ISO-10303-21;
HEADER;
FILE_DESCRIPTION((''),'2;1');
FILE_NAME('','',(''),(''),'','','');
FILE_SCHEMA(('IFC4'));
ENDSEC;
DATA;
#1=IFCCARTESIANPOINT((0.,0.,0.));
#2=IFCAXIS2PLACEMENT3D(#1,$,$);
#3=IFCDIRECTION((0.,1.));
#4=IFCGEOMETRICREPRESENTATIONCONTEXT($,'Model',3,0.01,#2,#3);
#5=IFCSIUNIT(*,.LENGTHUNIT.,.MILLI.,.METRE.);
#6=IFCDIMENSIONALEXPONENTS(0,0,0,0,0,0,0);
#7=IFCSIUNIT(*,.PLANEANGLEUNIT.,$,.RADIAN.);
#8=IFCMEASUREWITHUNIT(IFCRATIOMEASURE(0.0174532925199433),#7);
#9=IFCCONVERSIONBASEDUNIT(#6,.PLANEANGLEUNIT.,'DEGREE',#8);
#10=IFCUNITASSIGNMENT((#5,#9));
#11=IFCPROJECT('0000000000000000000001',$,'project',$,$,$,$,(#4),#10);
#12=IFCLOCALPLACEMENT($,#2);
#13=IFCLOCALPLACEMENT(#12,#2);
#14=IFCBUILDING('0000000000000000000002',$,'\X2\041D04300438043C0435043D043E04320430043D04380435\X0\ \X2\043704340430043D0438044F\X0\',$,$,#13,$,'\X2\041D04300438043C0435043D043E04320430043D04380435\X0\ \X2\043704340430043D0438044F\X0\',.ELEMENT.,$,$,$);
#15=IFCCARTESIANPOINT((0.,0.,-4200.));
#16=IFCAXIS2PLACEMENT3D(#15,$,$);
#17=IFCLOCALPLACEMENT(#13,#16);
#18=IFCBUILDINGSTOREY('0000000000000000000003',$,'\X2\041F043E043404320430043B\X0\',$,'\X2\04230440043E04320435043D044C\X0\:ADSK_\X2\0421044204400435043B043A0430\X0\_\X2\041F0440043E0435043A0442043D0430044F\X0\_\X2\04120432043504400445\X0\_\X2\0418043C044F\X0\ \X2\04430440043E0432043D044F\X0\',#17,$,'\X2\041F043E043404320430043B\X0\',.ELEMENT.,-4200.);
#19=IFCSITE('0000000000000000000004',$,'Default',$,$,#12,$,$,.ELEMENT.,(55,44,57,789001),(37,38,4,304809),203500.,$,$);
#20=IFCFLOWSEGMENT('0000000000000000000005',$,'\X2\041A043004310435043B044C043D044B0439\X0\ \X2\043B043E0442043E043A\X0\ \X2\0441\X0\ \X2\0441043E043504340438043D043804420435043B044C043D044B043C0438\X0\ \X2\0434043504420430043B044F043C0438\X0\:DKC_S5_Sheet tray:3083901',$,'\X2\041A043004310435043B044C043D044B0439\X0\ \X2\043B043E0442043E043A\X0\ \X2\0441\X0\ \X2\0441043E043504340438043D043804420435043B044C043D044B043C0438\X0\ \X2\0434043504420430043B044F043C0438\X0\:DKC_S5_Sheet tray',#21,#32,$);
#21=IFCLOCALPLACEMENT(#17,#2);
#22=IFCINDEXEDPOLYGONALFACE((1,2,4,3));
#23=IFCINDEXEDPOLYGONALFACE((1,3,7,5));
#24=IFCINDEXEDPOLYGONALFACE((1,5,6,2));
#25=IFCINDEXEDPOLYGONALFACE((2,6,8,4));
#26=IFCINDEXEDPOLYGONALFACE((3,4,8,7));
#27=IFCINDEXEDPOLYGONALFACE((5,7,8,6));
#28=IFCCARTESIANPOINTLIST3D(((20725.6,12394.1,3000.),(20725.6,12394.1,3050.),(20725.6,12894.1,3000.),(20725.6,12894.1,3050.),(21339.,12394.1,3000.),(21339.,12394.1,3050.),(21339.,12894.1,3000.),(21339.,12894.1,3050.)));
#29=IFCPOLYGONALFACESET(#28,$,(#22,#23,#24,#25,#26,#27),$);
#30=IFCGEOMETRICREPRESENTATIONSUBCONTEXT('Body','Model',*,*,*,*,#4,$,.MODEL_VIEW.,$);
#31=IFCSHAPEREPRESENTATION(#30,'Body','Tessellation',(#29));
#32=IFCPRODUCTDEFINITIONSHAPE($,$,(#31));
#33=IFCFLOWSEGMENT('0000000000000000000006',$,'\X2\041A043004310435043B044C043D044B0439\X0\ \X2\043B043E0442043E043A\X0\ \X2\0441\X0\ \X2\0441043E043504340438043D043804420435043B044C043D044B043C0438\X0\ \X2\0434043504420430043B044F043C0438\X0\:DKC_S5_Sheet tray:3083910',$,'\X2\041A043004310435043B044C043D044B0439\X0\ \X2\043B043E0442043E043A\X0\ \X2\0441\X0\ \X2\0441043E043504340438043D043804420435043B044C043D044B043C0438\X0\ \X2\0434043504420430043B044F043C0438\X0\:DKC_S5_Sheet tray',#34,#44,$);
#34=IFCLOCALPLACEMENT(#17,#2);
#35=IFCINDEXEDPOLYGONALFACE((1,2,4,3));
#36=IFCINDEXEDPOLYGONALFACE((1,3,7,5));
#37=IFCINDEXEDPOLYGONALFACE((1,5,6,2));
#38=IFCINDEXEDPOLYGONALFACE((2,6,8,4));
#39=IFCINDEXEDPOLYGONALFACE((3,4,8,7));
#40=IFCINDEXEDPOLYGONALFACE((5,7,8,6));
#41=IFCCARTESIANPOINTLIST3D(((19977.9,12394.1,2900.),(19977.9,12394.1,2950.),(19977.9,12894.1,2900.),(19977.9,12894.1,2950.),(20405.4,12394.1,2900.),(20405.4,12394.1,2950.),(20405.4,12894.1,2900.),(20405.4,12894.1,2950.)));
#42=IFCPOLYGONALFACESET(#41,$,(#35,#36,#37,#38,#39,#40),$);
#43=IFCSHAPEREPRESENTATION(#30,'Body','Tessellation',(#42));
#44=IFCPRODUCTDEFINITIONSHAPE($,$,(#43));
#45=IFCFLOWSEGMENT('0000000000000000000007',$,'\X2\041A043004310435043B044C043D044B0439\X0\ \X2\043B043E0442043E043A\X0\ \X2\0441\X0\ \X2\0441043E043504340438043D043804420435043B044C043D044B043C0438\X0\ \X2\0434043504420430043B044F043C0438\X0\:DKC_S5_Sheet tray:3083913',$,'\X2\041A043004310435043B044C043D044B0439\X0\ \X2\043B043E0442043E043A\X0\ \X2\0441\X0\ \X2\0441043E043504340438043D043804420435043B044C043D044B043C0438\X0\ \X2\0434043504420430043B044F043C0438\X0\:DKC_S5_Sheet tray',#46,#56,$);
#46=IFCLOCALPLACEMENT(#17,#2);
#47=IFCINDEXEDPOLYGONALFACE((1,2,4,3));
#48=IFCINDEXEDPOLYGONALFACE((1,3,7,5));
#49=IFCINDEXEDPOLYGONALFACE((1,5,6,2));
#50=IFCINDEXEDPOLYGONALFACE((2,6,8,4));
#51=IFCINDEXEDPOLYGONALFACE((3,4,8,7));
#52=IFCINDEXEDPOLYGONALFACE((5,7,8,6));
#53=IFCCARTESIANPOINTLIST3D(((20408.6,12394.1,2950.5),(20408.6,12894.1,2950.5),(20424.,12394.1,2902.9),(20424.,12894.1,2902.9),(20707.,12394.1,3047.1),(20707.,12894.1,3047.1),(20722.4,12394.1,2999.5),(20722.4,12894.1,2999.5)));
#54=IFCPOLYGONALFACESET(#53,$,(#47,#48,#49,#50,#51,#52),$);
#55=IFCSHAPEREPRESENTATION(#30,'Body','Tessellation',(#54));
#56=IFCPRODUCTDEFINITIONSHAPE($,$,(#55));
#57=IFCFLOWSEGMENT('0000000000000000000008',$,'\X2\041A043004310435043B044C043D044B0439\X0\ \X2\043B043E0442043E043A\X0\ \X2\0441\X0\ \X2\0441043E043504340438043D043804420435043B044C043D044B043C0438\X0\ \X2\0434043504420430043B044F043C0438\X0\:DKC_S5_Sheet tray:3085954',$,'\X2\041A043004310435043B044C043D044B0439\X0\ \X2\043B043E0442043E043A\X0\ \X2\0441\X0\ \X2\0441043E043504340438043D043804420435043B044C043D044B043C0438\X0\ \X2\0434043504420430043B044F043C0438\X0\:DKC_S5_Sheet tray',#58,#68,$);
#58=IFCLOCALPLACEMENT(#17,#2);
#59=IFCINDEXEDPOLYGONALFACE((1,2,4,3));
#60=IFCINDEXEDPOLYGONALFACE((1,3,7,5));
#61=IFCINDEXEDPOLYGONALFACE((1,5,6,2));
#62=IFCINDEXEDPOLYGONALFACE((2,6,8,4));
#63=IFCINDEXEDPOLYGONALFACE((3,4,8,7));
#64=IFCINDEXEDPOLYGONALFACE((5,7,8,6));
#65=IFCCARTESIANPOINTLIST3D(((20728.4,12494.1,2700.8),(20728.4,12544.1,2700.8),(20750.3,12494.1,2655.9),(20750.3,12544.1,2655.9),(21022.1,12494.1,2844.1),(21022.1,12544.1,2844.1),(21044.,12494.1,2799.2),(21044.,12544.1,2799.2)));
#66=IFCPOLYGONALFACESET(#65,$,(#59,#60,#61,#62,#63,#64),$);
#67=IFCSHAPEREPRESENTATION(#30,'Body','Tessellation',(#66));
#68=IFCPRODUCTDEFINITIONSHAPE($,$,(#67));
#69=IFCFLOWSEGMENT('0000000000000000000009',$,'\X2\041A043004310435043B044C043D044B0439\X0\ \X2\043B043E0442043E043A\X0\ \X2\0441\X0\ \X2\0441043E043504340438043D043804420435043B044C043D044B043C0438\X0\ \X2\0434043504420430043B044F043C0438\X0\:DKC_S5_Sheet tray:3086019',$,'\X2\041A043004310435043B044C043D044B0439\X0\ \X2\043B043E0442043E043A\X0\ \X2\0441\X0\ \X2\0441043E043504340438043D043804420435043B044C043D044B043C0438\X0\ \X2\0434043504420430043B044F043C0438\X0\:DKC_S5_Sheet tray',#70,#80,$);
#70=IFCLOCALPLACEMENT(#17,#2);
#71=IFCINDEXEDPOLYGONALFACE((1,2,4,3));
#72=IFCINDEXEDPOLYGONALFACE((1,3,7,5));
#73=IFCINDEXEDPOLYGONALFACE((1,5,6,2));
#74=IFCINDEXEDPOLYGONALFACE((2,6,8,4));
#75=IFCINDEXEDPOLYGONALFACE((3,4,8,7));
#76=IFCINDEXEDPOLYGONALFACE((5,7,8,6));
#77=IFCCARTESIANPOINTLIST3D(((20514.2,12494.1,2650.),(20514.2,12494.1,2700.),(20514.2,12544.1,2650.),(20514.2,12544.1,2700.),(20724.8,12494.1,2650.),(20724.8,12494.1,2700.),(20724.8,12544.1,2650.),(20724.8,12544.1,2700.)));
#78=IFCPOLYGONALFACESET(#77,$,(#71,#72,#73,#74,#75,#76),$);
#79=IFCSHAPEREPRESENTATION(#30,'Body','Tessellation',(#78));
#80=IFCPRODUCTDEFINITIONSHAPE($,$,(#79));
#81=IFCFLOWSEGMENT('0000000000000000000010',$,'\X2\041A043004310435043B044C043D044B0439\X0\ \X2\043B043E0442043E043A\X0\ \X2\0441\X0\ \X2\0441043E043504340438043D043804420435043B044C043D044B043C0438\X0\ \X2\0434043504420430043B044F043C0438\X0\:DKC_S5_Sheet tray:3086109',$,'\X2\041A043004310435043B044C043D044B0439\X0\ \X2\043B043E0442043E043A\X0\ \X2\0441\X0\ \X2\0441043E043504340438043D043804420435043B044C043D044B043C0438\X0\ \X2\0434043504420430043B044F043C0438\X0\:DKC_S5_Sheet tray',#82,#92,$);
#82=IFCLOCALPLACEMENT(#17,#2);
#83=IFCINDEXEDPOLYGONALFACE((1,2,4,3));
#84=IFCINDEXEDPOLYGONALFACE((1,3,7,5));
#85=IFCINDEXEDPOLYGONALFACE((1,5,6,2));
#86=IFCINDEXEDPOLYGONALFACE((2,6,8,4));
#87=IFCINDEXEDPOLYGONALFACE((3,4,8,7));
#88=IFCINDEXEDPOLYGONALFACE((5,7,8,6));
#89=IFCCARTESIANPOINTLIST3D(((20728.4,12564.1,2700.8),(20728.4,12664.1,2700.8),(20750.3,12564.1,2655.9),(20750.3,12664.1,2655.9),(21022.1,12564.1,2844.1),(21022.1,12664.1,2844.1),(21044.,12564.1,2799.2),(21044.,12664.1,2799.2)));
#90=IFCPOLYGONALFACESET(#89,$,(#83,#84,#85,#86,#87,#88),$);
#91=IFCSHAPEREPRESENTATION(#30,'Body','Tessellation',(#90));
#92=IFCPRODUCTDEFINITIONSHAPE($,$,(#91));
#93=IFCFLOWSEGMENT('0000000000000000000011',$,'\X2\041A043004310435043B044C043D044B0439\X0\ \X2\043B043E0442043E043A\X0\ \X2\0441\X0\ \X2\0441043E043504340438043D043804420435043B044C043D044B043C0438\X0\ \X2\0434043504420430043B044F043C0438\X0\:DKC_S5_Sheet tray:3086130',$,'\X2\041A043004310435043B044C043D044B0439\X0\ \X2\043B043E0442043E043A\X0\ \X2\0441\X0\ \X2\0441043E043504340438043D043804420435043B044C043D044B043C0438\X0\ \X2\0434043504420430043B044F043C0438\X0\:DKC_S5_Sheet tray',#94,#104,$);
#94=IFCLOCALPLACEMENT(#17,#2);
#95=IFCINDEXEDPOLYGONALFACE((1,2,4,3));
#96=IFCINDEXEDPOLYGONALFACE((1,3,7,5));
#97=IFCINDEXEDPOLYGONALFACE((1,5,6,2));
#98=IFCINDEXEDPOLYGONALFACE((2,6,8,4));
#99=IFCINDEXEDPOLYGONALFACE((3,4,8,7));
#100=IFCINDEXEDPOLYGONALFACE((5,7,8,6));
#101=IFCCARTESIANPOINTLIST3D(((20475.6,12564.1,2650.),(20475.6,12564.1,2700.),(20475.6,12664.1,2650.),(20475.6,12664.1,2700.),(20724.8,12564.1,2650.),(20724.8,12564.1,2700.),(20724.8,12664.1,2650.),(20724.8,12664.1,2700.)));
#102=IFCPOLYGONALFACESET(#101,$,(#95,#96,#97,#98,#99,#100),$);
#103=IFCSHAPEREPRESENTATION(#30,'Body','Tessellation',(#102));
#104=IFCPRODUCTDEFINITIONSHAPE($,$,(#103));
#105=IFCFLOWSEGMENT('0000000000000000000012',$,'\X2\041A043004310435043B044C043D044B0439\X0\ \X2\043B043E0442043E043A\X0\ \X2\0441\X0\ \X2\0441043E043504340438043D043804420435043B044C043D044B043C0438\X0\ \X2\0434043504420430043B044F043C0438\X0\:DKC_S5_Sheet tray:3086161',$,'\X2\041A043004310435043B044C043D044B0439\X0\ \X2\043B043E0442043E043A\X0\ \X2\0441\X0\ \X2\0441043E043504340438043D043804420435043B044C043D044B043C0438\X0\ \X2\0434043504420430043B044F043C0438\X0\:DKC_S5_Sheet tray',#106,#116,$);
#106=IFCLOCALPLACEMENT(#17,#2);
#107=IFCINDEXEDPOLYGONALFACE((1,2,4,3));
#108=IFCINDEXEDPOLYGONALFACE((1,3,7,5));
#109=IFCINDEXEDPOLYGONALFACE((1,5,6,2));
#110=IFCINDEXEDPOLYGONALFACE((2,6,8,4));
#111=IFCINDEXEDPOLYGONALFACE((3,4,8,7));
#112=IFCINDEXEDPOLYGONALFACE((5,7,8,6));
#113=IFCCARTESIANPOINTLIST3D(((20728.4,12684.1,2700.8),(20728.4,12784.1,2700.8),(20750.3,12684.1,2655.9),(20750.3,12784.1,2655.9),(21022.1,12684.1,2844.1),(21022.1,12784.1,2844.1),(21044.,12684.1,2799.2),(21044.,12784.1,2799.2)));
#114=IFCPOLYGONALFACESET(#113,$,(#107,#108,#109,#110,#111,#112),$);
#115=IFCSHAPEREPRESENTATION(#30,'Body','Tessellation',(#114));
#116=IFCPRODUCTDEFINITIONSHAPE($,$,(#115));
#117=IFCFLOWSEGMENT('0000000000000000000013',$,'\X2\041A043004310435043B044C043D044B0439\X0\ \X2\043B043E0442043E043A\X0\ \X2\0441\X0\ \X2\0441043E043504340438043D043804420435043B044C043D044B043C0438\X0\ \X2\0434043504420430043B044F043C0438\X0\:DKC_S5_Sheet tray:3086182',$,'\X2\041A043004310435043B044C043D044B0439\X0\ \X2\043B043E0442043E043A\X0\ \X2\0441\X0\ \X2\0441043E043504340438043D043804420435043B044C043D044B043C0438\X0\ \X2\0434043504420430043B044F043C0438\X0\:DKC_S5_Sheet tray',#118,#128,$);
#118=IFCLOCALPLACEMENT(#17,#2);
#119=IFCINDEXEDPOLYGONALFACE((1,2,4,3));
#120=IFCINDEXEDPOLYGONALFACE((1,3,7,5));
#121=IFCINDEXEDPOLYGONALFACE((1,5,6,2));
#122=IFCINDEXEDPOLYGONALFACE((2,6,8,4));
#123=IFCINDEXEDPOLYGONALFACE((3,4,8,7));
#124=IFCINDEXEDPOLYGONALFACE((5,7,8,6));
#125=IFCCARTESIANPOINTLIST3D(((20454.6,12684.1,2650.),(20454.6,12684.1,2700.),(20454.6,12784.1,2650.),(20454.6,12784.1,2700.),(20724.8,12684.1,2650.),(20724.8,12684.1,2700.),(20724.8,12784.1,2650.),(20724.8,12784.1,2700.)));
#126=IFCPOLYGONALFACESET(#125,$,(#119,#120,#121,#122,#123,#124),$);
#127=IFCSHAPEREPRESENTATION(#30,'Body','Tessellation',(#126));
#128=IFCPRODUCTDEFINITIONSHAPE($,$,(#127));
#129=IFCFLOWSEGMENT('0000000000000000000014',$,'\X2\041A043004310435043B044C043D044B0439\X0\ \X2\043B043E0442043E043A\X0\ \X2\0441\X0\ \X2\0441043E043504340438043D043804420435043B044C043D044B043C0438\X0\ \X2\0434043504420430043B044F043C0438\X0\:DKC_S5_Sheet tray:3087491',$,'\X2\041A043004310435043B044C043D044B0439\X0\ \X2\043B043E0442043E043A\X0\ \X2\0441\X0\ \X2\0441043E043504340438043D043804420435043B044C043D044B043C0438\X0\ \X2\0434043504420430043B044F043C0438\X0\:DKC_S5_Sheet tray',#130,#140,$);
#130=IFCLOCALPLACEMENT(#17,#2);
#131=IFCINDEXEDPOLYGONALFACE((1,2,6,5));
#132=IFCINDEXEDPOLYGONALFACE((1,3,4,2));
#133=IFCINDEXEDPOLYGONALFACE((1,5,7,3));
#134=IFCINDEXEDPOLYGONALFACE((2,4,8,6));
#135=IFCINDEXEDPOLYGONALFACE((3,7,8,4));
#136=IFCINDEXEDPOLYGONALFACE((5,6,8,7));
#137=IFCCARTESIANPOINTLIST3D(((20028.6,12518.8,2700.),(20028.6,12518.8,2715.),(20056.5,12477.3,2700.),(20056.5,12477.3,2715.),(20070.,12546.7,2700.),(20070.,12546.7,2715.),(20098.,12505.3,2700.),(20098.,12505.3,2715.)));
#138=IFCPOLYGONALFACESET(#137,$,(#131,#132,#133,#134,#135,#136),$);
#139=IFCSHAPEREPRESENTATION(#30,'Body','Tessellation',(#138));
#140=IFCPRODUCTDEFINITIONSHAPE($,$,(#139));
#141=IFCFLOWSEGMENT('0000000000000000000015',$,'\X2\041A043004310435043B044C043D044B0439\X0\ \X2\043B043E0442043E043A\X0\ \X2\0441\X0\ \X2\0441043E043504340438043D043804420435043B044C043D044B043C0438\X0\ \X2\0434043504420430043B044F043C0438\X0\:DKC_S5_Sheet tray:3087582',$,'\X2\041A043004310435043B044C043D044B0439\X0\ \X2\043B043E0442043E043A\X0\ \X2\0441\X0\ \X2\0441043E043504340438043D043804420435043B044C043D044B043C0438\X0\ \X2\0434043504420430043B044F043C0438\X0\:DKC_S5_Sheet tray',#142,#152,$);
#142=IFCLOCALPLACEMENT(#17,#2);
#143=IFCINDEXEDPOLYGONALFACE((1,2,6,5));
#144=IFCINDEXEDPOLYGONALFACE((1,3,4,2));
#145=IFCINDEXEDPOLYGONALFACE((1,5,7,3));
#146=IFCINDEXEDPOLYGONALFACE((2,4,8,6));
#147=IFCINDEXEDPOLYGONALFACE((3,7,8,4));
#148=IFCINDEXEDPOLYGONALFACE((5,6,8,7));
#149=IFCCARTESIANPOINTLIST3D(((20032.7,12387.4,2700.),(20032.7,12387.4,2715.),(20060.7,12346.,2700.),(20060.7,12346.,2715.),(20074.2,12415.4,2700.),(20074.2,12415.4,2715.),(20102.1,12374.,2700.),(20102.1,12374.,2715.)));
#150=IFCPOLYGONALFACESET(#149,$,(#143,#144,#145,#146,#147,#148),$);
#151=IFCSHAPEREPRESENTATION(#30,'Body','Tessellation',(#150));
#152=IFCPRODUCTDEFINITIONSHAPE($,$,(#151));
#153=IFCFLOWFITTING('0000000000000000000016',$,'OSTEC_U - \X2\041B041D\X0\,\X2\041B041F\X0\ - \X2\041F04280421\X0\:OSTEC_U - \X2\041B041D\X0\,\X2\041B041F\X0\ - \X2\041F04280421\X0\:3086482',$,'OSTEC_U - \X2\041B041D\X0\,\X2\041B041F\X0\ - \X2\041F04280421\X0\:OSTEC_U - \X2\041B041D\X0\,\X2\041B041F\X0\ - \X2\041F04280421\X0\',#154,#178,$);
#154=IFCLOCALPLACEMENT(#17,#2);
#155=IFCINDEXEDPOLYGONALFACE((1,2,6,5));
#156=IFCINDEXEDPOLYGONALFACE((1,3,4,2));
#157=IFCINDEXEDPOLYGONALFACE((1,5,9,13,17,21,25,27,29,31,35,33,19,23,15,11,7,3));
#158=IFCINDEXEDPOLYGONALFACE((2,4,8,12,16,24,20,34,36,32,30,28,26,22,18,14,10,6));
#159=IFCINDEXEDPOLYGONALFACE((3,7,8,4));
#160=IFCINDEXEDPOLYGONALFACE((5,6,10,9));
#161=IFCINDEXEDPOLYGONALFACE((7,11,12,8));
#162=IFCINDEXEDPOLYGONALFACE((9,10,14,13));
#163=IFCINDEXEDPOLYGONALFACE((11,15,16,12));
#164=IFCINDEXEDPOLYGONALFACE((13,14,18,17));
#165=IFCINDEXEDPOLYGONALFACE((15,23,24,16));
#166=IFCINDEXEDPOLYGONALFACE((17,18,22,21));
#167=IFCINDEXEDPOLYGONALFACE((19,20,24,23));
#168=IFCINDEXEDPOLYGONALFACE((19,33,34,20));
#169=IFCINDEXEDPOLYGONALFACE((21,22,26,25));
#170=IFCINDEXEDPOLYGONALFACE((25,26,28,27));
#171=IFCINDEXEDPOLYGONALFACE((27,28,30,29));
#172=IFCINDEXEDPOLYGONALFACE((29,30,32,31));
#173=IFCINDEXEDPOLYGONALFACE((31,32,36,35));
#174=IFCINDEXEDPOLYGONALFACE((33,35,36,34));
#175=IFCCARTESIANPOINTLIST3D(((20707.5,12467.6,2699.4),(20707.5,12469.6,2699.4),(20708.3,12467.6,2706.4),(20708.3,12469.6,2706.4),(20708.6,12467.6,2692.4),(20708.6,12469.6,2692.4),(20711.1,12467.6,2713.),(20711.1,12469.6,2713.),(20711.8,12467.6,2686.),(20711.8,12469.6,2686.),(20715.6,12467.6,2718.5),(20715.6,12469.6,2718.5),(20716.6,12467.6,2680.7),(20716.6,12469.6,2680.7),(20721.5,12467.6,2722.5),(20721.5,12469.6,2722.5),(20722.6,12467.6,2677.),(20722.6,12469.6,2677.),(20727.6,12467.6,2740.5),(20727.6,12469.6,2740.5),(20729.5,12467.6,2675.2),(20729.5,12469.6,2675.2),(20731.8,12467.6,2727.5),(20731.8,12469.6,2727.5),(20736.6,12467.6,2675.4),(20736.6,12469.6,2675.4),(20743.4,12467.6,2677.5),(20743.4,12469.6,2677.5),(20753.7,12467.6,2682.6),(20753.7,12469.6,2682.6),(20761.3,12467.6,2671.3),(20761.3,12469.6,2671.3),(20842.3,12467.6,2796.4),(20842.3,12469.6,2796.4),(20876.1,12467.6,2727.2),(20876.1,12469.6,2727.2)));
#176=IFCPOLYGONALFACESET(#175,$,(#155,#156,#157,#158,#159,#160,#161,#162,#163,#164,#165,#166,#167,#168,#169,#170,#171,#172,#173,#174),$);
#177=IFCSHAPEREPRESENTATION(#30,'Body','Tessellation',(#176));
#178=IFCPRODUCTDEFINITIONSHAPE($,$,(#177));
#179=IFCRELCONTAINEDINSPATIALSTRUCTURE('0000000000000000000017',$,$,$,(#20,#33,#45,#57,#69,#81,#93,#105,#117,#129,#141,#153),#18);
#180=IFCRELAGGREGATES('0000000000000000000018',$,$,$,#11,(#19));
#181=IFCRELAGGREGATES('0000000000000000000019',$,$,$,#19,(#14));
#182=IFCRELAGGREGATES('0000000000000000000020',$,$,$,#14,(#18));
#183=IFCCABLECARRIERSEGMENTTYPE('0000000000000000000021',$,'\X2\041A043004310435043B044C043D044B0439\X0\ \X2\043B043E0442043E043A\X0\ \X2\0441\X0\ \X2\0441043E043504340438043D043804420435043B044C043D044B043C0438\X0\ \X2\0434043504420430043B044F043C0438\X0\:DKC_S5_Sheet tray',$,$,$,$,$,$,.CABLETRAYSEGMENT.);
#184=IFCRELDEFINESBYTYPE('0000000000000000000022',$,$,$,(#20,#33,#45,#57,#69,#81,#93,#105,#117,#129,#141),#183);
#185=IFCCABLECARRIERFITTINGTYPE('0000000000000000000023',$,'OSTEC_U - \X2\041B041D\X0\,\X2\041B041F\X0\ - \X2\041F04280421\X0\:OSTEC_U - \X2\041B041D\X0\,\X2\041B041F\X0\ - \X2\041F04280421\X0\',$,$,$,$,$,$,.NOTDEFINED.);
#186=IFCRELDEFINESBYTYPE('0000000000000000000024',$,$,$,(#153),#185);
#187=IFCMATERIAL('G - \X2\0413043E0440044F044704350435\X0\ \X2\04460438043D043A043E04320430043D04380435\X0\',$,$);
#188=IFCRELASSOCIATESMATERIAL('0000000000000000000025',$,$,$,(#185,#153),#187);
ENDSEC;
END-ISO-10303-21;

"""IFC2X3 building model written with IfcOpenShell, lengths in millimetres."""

from ifc_helpers import new_model, entity, si_unit, converted_unit, direction, frame, frame_2d, origin, origin_2d_with_axis, place, context, subcontext, project, spatial, polyline, circle_curve, parameter, trimmed, segment, composite_curve, rectangle, outline, extrude, source, transform, mapped, material, type_object, type_shapes, element, save


model = new_model("IFC2X3")

# Units and contexts
model_context = context("Model", 3, precision=0.01, world=origin(), true_north=direction((0.0, 1.0)))
body_context = subcontext(model_context, "Body", "Model", "MODEL_VIEW")
ifc_project = project(units=[si_unit("LENGTHUNIT", "METRE", prefix="MILLI"), converted_unit("PLANEANGLEUNIT", "DEGREE", entity("IfcRatioMeasure", 0.0174532925199433), si_unit("PLANEANGLEUNIT", "RADIAN"), dimensions=[0, 0, 0, 0, 0, 0, 0])], contexts=[model_context])

# Site, building, storey
site_placement = place(None, origin())
site = spatial("IfcSite", under=ifc_project, at=site_placement, Name="Default", CompositionType="ELEMENT", RefLatitude=(55, 44, 57, 789001), RefLongitude=(37, 38, 4, 304809), RefElevation=203500.0)
building_placement = place(site_placement, origin())
building = spatial("IfcBuilding", under=site, at=building_placement, Name="Наименование здания", LongName="Наименование здания", CompositionType="ELEMENT")
storey_placement = place(building_placement, frame((0.0, 0.0, -4200.0)))
storey = spatial("IfcBuildingStorey", under=building, at=storey_placement, Name="Подвал", ObjectType="Уровень:ADSK_Стрелка_Проектная_Вверх_Имя уровня", LongName="Подвал", CompositionType="ELEMENT", Elevation=-4200.0)

# Flow segments
cable_carrier_segment_type = type_object("IfcCableCarrierSegmentType", Name="Кабельный лоток с соединительными деталями:DKC_S5_Sheet tray", PredefinedType="CABLETRAYSEGMENT")
flow_segment_1_placement = place(storey_placement, frame((20725.6, 12394.1, 3000.0)))
element("IfcFlowSegment", 1, at=flow_segment_1_placement, inside=storey, type_object=cable_carrier_segment_type, Name="Кабельный лоток с соединительными деталями:DKC_S5_Sheet tray:3083901", ObjectType="Кабельный лоток с соединительными деталями:DKC_S5_Sheet tray", context=body_context, shape_type="SweptSolid", body=[
    extrude(rectangle(XDim=613.4, YDim=500.0, at=origin_2d_with_axis()), frame((306.7, 250.0, 0.0), z_axis=(0.0, 0.0, 1.0), x_axis=(-1.0, 0.0, 0.0)), (0.0, 0.0, 1.0), 50.0),
])
flow_segment_2_placement = place(storey_placement, frame((19977.9, 12394.1, 2900.0)))
element("IfcFlowSegment", 2, at=flow_segment_2_placement, inside=storey, type_object=cable_carrier_segment_type, Name="Кабельный лоток с соединительными деталями:DKC_S5_Sheet tray:3083910", ObjectType="Кабельный лоток с соединительными деталями:DKC_S5_Sheet tray", context=body_context, shape_type="SweptSolid", body=[
    extrude(rectangle(XDim=427.5, YDim=500.0, at=origin_2d_with_axis()), frame((213.7, 250.0, 0.0)), (0.0, 0.0, 1.0), 50.0),
])
flow_segment_3_placement = place(storey_placement, frame((20408.6, 12394.1, 2902.9)))
element("IfcFlowSegment", 3, at=flow_segment_3_placement, inside=storey, type_object=cable_carrier_segment_type, Name="Кабельный лоток с соединительными деталями:DKC_S5_Sheet tray:3083913", ObjectType="Кабельный лоток с соединительными деталями:DKC_S5_Sheet tray", context=body_context, shape_type="SweptSolid", body=[
    extrude(rectangle(XDim=50.0, YDim=313.7, at=frame_2d((0.0, 0.0), x_axis=(0.0, 1.0))), frame((156.9, 0.0, 72.1), z_axis=(0.0, 1.0, 0.0), x_axis=(0.951427, 0.0, 0.307875)), (0.0, 0.0, 1.0), 500.0),
])
flow_segment_4_placement = place(storey_placement, frame((20728.4, 12494.1, 2655.9)))
element("IfcFlowSegment", 4, at=flow_segment_4_placement, inside=storey, type_object=cable_carrier_segment_type, Name="Кабельный лоток с соединительными деталями:DKC_S5_Sheet tray:3085954", ObjectType="Кабельный лоток с соединительными деталями:DKC_S5_Sheet tray", context=body_context, shape_type="SweptSolid", body=[
    extrude(rectangle(XDim=50.0, YDim=50.0, at=origin_2d_with_axis()), frame((11.0, 25.0, 22.5), z_axis=(0.898794, 0.0, 0.438371), x_axis=(-0.438371, 0.0, 0.898794)), (0.0, 0.0, 1.0), 326.8),
])
flow_segment_5_placement = place(storey_placement, frame((20514.2, 12494.1, 2650.0)))
element("IfcFlowSegment", 5, at=flow_segment_5_placement, inside=storey, type_object=cable_carrier_segment_type, Name="Кабельный лоток с соединительными деталями:DKC_S5_Sheet tray:3086019", ObjectType="Кабельный лоток с соединительными деталями:DKC_S5_Sheet tray", context=body_context, shape_type="SweptSolid", body=[
    extrude(rectangle(XDim=210.6, YDim=50.0, at=origin_2d_with_axis()), frame((105.3, 25.0, 0.0), z_axis=(0.0, 0.0, 1.0), x_axis=(-1.0, 0.0, 0.0)), (0.0, 0.0, 1.0), 50.0),
])
flow_segment_6_placement = place(storey_placement, frame((20728.4, 12564.1, 2655.9)))
element("IfcFlowSegment", 6, at=flow_segment_6_placement, inside=storey, type_object=cable_carrier_segment_type, Name="Кабельный лоток с соединительными деталями:DKC_S5_Sheet tray:3086109", ObjectType="Кабельный лоток с соединительными деталями:DKC_S5_Sheet tray", context=body_context, shape_type="SweptSolid", body=[
    extrude(rectangle(XDim=50.0, YDim=100.0, at=origin_2d_with_axis()), frame((11.0, 50.0, 22.5), z_axis=(0.898794, 0.0, 0.438371), x_axis=(-0.438371, 0.0, 0.898794)), (0.0, 0.0, 1.0), 326.8),
])
flow_segment_7_placement = place(storey_placement, frame((20475.5, 12564.1, 2650.0)))
element("IfcFlowSegment", 7, at=flow_segment_7_placement, inside=storey, type_object=cable_carrier_segment_type, Name="Кабельный лоток с соединительными деталями:DKC_S5_Sheet tray:3086130", ObjectType="Кабельный лоток с соединительными деталями:DKC_S5_Sheet tray", context=body_context, shape_type="SweptSolid", body=[
    extrude(rectangle(XDim=249.2, YDim=100.0, at=origin_2d_with_axis()), frame((124.6, 50.0, 0.0), z_axis=(0.0, 0.0, 1.0), x_axis=(-1.0, 0.0, 0.0)), (0.0, 0.0, 1.0), 50.0),
])
flow_segment_8_placement = place(storey_placement, frame((20728.4, 12684.1, 2655.9)))
element("IfcFlowSegment", 8, at=flow_segment_8_placement, inside=storey, type_object=cable_carrier_segment_type, Name="Кабельный лоток с соединительными деталями:DKC_S5_Sheet tray:3086161", ObjectType="Кабельный лоток с соединительными деталями:DKC_S5_Sheet tray", context=body_context, shape_type="SweptSolid", body=[
    extrude(rectangle(XDim=50.0, YDim=100.0, at=origin_2d_with_axis()), frame((11.0, 50.0, 22.5), z_axis=(0.898794, 0.0, 0.438371), x_axis=(-0.438371, 0.0, 0.898794)), (0.0, 0.0, 1.0), 326.8),
])
flow_segment_9_placement = place(storey_placement, frame((20454.6, 12684.1, 2650.0)))
element("IfcFlowSegment", 9, at=flow_segment_9_placement, inside=storey, type_object=cable_carrier_segment_type, Name="Кабельный лоток с соединительными деталями:DKC_S5_Sheet tray:3086182", ObjectType="Кабельный лоток с соединительными деталями:DKC_S5_Sheet tray", context=body_context, shape_type="SweptSolid", body=[
    extrude(rectangle(XDim=270.2, YDim=100.0, at=origin_2d_with_axis()), frame((135.1, 50.0, 0.0), z_axis=(0.0, 0.0, 1.0), x_axis=(-1.0, 0.0, 0.0)), (0.0, 0.0, 1.0), 50.0),
])
flow_segment_10_placement = place(storey_placement, frame((20028.5, 12477.3, 2700.0)))
element("IfcFlowSegment", 10, at=flow_segment_10_placement, inside=storey, type_object=cable_carrier_segment_type, Name="Кабельный лоток с соединительными деталями:DKC_S5_Sheet tray:3087491", ObjectType="Кабельный лоток с соединительными деталями:DKC_S5_Sheet tray", context=body_context, shape_type="SweptSolid", body=[
    extrude(rectangle(XDim=50.0, YDim=50.0, at=origin_2d_with_axis()), frame((34.7, 34.7, 0.0), z_axis=(0.0, 0.0, 1.0), x_axis=(-0.829038, -0.559193, 0.0)), (0.0, 0.0, 1.0), 15.0),
])
flow_segment_11_placement = place(storey_placement, frame((20032.7, 12346.0, 2700.0)))
element("IfcFlowSegment", 11, at=flow_segment_11_placement, inside=storey, type_object=cable_carrier_segment_type, Name="Кабельный лоток с соединительными деталями:DKC_S5_Sheet tray:3087582", ObjectType="Кабельный лоток с соединительными деталями:DKC_S5_Sheet tray", context=body_context, shape_type="SweptSolid", body=[
    extrude(rectangle(XDim=50.0, YDim=50.0, at=origin_2d_with_axis()), frame((34.7, 34.7, 0.0), z_axis=(0.0, 0.0, 1.0), x_axis=(-0.829038, -0.559193, 0.0)), (0.0, 0.0, 1.0), 15.0),
])

# Flow fitting
ifc_material_1 = material(Name="G - Горячее цинкование")
cable_carrier_fitting_type_1 = type_object("IfcCableCarrierFittingType", Name="OSTEC_U - ЛН,ЛП - ПШС:OSTEC_U - ЛН,ЛП - ПШС", PredefinedType="NOTDEFINED", material=ifc_material_1)
shared_shape_1 = source(origin(), body_context, "Body", "SweptSolid", [
    extrude(outline(composite_curve([segment(trimmed(circle_curve(frame_2d((-41.5, 0.0), x_axis=(1.0, 0.0)), 25.0), [parameter(90.0)], [parameter(270.0)], True, "PARAMETER"), True, "CONTINUOUS"), segment(polyline([(-41.5, -25.0), (-30.0, -25.0)]), True, "CONTINUOUS"), segment(polyline([(-30.0, -25.0), (-28.1, -38.5)]), True, "CONTINUOUS"), segment(polyline([(-28.1, -38.5), (99.5, -38.5)]), True, "CONTINUOUS"), segment(polyline([(99.5, -38.5), (99.5, 38.5)]), True, "CONTINUOUS"), segment(polyline([(99.5, 38.5), (-28.1, 38.5)]), True, "CONTINUOUS"), segment(polyline([(-28.1, 38.5), (-30.0, 25.0)]), True, "CONTINUOUS"), segment(polyline([(-30.0, 25.0), (-41.5, 25.0)]), True, "CONTINUOUS")], self_intersect=False)), frame((41.5, 0.0, 0.0)), (0.0, 0.0, 1.0), 2.0),
])
type_shapes(cable_carrier_fitting_type_1, [shared_shape_1])
flow_fitting_1_placement = place(storey_placement, frame((20732.5, 12467.6, 2700.0), z_axis=(0.0, 1.0, 0.0), x_axis=(0.898794, 0.0, 0.438371)))
element("IfcFlowFitting", 12, at=flow_fitting_1_placement, inside=storey, type_object=cable_carrier_fitting_type_1, material=ifc_material_1, Name="OSTEC_U - ЛН,ЛП - ПШС:OSTEC_U - ЛН,ЛП - ПШС:3086482", ObjectType="OSTEC_U - ЛН,ЛП - ПШС:OSTEC_U - ЛН,ЛП - ПШС", context=body_context, shape_type="MappedRepresentation", body=[
    mapped(shared_shape_1, transform((0.0, 0.0, 0.0), scale=1.0)),
])

save(model, "model.ifc")
